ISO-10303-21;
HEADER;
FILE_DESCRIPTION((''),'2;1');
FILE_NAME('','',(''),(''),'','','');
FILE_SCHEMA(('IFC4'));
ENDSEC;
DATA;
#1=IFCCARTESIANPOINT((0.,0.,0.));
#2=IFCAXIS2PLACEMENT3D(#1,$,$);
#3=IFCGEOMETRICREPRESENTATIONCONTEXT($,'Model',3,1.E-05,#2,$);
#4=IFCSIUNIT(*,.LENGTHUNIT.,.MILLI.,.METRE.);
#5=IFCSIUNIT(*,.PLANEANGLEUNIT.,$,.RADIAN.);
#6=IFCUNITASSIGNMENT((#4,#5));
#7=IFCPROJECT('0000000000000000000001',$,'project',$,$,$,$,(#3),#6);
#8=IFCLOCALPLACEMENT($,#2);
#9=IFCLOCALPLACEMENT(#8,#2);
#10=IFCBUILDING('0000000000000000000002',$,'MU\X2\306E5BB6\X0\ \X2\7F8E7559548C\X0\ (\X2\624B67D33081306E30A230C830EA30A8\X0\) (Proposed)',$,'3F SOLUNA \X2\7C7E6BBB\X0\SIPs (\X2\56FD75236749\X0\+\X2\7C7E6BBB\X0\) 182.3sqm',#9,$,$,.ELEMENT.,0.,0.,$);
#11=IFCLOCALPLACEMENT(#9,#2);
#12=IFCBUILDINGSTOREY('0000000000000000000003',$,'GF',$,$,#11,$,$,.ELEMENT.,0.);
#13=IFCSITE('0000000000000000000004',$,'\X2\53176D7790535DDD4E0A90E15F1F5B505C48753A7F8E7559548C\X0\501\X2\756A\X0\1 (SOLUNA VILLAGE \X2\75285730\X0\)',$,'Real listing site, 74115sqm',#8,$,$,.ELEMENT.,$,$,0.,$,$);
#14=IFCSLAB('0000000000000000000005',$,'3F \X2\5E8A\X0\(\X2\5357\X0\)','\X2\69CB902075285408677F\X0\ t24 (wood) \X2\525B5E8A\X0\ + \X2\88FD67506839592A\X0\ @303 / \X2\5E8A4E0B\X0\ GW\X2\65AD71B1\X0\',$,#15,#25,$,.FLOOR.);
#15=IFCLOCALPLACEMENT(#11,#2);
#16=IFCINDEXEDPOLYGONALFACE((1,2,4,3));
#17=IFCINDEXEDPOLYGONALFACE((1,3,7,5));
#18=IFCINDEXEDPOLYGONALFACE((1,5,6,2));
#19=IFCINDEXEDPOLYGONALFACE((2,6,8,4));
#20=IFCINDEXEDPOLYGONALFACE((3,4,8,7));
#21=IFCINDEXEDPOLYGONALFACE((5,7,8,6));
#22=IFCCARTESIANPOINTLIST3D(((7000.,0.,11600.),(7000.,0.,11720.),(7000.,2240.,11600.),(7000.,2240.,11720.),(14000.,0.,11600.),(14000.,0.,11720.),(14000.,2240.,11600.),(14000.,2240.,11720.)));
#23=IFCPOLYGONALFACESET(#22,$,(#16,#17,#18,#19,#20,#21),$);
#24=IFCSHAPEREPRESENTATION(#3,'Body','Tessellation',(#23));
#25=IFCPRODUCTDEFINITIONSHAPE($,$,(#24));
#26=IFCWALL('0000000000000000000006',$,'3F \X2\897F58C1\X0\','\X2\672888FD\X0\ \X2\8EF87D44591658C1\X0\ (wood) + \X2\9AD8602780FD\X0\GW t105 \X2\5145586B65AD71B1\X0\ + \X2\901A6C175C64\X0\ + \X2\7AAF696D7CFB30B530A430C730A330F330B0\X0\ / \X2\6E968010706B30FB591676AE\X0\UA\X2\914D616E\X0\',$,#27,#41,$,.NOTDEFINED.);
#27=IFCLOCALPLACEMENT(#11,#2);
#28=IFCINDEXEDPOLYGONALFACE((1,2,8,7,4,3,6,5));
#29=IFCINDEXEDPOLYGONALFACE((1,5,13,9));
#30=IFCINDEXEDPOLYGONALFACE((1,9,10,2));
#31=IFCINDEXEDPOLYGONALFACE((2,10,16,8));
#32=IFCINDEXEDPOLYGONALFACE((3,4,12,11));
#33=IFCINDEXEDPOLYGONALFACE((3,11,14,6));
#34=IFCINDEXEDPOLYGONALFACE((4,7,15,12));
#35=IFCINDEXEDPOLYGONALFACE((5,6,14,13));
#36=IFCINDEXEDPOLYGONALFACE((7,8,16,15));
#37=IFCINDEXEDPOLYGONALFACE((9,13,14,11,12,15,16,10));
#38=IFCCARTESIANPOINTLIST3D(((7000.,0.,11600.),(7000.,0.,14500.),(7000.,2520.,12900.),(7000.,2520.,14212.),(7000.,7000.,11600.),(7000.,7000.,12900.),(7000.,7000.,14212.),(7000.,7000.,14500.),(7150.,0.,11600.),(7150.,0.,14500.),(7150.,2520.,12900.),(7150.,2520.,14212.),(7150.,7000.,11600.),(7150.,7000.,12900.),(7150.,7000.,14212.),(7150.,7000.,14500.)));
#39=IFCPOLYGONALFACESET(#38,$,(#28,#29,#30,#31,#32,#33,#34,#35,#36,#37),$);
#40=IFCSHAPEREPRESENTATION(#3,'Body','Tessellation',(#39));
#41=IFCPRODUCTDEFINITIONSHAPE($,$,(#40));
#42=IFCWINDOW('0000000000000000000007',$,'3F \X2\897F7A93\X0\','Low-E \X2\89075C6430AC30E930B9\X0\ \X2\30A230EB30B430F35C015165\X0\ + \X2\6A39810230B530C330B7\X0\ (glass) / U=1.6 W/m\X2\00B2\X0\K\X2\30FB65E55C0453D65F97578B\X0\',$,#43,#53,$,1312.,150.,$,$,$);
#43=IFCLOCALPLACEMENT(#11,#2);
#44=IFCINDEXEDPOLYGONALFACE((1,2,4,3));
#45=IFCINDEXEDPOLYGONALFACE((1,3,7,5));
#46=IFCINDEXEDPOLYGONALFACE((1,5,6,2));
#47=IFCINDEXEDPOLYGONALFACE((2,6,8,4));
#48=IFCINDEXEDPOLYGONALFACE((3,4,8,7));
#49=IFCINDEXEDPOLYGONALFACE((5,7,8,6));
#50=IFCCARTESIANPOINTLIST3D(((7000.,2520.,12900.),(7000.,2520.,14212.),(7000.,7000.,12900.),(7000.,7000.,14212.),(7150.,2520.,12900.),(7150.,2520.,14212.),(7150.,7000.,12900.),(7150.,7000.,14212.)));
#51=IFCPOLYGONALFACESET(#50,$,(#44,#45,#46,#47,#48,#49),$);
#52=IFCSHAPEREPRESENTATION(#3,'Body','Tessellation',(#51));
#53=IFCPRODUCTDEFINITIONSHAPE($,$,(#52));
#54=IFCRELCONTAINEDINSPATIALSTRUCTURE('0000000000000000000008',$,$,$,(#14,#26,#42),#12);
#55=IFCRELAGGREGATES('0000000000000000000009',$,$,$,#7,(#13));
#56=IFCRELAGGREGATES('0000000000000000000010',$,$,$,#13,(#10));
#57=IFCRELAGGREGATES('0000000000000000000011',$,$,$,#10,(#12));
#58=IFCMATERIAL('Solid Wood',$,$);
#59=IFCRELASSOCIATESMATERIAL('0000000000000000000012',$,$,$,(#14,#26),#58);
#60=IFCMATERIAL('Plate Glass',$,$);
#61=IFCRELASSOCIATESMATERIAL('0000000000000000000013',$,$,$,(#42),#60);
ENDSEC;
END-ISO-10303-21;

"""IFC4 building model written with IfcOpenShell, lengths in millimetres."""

from ifc_helpers import new_model, si_unit, frame, frame_2d, origin, place, context, project, spatial, rectangle, extrude, material, element, fill, save


model = new_model("IFC4")

# Units and contexts
model_context = context("Model", 3, precision=1e-05, world=origin())
ifc_project = project(units=[si_unit("LENGTHUNIT", "METRE", prefix="MILLI"), si_unit("PLANEANGLEUNIT", "RADIAN")], contexts=[model_context])

# Site, building, storey
site_placement = place(None, origin())
site = spatial("IfcSite", under=ifc_project, at=site_placement, Name="北海道川上郡弟子屈町美留和501番1 (SOLUNA VILLAGE 用地)", ObjectType="Real listing site, 74115sqm", CompositionType="ELEMENT", RefElevation=0.0)
building_placement = place(site_placement, origin())
building = spatial("IfcBuilding", under=site, at=building_placement, Name="MUの家 美留和 (手染めのアトリエ) (Proposed)", ObjectType="3F SOLUNA 籾殻SIPs (国産杉+籾殻) 182.3sqm", CompositionType="ELEMENT", ElevationOfRefHeight=0.0, ElevationOfTerrain=0.0)
storey_placement = place(building_placement, origin())
storey = spatial("IfcBuildingStorey", under=building, at=storey_placement, Name="GF", CompositionType="ELEMENT", Elevation=0.0)

# Slab
ifc_material_1 = material(Name="Solid Wood")
slab_1_placement = place(storey_placement, frame((3500.0, 0.0, 5800.0)))
element("IfcSlab", 1, at=slab_1_placement, inside=storey, material=ifc_material_1, Name="3F 床(南)", Description="構造用合板 t24 (wood) 剛床 + 製材根太 @303 / 床下 GW断熱", PredefinedType="FLOOR", context=model_context, shape_type="SweptSolid", body=[
    extrude(rectangle(XDim=7000.0, YDim=2240.0, at=frame_2d((3500.0, 1120.0))), frame((3500.0, 0.0, 5800.0)), (0.0, 0.0, 1.0), 120.0),
])

# Shared definitions
ifc_material_2 = material(Name="Plate Glass")

# Wall, opening, window
wall_1_placement = place(storey_placement, frame((3500.0, 0.0, 5800.0)))
wall_1 = element("IfcWall", 2, at=wall_1_placement, inside=storey, material=ifc_material_1, Name="3F 西壁", Description="木製 軸組外壁 (wood) + 高性能GW t105 充填断熱 + 通気層 + 窯業系サイディング / 準耐火・外皮UA配慮", PredefinedType="NOTDEFINED", context=model_context, shape_type="SweptSolid", body=[
    extrude(rectangle(XDim=150.0, YDim=7000.0, at=frame_2d((75.0, 3500.0))), frame((3500.0, 0.0, 5800.0)), (0.0, 0.0, 1.0), 2900.0),
])
opening_1_placement = place(storey_placement, frame((3500.0, 1260.0, 6450.0)))
opening_1 = element("IfcOpeningElement", 3, at=opening_1_placement, cuts=wall_1, PredefinedType="NOTDEFINED", context=model_context, shape_type="SweptSolid", body=[
    extrude(rectangle(XDim=150.0, YDim=4480.0, at=frame_2d((75.0, 2240.0))), frame((3500.0, 1260.0, 6450.0)), (0.0, 0.0, 1.0), 1312.0),
])
window_1_placement = place(storey_placement, frame((3500.0, 1260.0, 6450.0)))
window_1 = element("IfcWindow", 4, at=window_1_placement, inside=storey, material=ifc_material_2, Name="3F 西窓", Description="Low-E 複層ガラス アルゴン封入 + 樹脂サッシ (glass) / U=1.6 W/m²K・日射取得型", OverallHeight=1312.0, OverallWidth=150.0, context=model_context, shape_type="SweptSolid", body=[
    extrude(rectangle(XDim=150.0, YDim=4480.0, at=frame_2d((75.0, 2240.0))), frame((3500.0, 1260.0, 6450.0)), (0.0, 0.0, 1.0), 1312.0),
])
fill(opening_1, window_1)

save(model, "model.ifc")
